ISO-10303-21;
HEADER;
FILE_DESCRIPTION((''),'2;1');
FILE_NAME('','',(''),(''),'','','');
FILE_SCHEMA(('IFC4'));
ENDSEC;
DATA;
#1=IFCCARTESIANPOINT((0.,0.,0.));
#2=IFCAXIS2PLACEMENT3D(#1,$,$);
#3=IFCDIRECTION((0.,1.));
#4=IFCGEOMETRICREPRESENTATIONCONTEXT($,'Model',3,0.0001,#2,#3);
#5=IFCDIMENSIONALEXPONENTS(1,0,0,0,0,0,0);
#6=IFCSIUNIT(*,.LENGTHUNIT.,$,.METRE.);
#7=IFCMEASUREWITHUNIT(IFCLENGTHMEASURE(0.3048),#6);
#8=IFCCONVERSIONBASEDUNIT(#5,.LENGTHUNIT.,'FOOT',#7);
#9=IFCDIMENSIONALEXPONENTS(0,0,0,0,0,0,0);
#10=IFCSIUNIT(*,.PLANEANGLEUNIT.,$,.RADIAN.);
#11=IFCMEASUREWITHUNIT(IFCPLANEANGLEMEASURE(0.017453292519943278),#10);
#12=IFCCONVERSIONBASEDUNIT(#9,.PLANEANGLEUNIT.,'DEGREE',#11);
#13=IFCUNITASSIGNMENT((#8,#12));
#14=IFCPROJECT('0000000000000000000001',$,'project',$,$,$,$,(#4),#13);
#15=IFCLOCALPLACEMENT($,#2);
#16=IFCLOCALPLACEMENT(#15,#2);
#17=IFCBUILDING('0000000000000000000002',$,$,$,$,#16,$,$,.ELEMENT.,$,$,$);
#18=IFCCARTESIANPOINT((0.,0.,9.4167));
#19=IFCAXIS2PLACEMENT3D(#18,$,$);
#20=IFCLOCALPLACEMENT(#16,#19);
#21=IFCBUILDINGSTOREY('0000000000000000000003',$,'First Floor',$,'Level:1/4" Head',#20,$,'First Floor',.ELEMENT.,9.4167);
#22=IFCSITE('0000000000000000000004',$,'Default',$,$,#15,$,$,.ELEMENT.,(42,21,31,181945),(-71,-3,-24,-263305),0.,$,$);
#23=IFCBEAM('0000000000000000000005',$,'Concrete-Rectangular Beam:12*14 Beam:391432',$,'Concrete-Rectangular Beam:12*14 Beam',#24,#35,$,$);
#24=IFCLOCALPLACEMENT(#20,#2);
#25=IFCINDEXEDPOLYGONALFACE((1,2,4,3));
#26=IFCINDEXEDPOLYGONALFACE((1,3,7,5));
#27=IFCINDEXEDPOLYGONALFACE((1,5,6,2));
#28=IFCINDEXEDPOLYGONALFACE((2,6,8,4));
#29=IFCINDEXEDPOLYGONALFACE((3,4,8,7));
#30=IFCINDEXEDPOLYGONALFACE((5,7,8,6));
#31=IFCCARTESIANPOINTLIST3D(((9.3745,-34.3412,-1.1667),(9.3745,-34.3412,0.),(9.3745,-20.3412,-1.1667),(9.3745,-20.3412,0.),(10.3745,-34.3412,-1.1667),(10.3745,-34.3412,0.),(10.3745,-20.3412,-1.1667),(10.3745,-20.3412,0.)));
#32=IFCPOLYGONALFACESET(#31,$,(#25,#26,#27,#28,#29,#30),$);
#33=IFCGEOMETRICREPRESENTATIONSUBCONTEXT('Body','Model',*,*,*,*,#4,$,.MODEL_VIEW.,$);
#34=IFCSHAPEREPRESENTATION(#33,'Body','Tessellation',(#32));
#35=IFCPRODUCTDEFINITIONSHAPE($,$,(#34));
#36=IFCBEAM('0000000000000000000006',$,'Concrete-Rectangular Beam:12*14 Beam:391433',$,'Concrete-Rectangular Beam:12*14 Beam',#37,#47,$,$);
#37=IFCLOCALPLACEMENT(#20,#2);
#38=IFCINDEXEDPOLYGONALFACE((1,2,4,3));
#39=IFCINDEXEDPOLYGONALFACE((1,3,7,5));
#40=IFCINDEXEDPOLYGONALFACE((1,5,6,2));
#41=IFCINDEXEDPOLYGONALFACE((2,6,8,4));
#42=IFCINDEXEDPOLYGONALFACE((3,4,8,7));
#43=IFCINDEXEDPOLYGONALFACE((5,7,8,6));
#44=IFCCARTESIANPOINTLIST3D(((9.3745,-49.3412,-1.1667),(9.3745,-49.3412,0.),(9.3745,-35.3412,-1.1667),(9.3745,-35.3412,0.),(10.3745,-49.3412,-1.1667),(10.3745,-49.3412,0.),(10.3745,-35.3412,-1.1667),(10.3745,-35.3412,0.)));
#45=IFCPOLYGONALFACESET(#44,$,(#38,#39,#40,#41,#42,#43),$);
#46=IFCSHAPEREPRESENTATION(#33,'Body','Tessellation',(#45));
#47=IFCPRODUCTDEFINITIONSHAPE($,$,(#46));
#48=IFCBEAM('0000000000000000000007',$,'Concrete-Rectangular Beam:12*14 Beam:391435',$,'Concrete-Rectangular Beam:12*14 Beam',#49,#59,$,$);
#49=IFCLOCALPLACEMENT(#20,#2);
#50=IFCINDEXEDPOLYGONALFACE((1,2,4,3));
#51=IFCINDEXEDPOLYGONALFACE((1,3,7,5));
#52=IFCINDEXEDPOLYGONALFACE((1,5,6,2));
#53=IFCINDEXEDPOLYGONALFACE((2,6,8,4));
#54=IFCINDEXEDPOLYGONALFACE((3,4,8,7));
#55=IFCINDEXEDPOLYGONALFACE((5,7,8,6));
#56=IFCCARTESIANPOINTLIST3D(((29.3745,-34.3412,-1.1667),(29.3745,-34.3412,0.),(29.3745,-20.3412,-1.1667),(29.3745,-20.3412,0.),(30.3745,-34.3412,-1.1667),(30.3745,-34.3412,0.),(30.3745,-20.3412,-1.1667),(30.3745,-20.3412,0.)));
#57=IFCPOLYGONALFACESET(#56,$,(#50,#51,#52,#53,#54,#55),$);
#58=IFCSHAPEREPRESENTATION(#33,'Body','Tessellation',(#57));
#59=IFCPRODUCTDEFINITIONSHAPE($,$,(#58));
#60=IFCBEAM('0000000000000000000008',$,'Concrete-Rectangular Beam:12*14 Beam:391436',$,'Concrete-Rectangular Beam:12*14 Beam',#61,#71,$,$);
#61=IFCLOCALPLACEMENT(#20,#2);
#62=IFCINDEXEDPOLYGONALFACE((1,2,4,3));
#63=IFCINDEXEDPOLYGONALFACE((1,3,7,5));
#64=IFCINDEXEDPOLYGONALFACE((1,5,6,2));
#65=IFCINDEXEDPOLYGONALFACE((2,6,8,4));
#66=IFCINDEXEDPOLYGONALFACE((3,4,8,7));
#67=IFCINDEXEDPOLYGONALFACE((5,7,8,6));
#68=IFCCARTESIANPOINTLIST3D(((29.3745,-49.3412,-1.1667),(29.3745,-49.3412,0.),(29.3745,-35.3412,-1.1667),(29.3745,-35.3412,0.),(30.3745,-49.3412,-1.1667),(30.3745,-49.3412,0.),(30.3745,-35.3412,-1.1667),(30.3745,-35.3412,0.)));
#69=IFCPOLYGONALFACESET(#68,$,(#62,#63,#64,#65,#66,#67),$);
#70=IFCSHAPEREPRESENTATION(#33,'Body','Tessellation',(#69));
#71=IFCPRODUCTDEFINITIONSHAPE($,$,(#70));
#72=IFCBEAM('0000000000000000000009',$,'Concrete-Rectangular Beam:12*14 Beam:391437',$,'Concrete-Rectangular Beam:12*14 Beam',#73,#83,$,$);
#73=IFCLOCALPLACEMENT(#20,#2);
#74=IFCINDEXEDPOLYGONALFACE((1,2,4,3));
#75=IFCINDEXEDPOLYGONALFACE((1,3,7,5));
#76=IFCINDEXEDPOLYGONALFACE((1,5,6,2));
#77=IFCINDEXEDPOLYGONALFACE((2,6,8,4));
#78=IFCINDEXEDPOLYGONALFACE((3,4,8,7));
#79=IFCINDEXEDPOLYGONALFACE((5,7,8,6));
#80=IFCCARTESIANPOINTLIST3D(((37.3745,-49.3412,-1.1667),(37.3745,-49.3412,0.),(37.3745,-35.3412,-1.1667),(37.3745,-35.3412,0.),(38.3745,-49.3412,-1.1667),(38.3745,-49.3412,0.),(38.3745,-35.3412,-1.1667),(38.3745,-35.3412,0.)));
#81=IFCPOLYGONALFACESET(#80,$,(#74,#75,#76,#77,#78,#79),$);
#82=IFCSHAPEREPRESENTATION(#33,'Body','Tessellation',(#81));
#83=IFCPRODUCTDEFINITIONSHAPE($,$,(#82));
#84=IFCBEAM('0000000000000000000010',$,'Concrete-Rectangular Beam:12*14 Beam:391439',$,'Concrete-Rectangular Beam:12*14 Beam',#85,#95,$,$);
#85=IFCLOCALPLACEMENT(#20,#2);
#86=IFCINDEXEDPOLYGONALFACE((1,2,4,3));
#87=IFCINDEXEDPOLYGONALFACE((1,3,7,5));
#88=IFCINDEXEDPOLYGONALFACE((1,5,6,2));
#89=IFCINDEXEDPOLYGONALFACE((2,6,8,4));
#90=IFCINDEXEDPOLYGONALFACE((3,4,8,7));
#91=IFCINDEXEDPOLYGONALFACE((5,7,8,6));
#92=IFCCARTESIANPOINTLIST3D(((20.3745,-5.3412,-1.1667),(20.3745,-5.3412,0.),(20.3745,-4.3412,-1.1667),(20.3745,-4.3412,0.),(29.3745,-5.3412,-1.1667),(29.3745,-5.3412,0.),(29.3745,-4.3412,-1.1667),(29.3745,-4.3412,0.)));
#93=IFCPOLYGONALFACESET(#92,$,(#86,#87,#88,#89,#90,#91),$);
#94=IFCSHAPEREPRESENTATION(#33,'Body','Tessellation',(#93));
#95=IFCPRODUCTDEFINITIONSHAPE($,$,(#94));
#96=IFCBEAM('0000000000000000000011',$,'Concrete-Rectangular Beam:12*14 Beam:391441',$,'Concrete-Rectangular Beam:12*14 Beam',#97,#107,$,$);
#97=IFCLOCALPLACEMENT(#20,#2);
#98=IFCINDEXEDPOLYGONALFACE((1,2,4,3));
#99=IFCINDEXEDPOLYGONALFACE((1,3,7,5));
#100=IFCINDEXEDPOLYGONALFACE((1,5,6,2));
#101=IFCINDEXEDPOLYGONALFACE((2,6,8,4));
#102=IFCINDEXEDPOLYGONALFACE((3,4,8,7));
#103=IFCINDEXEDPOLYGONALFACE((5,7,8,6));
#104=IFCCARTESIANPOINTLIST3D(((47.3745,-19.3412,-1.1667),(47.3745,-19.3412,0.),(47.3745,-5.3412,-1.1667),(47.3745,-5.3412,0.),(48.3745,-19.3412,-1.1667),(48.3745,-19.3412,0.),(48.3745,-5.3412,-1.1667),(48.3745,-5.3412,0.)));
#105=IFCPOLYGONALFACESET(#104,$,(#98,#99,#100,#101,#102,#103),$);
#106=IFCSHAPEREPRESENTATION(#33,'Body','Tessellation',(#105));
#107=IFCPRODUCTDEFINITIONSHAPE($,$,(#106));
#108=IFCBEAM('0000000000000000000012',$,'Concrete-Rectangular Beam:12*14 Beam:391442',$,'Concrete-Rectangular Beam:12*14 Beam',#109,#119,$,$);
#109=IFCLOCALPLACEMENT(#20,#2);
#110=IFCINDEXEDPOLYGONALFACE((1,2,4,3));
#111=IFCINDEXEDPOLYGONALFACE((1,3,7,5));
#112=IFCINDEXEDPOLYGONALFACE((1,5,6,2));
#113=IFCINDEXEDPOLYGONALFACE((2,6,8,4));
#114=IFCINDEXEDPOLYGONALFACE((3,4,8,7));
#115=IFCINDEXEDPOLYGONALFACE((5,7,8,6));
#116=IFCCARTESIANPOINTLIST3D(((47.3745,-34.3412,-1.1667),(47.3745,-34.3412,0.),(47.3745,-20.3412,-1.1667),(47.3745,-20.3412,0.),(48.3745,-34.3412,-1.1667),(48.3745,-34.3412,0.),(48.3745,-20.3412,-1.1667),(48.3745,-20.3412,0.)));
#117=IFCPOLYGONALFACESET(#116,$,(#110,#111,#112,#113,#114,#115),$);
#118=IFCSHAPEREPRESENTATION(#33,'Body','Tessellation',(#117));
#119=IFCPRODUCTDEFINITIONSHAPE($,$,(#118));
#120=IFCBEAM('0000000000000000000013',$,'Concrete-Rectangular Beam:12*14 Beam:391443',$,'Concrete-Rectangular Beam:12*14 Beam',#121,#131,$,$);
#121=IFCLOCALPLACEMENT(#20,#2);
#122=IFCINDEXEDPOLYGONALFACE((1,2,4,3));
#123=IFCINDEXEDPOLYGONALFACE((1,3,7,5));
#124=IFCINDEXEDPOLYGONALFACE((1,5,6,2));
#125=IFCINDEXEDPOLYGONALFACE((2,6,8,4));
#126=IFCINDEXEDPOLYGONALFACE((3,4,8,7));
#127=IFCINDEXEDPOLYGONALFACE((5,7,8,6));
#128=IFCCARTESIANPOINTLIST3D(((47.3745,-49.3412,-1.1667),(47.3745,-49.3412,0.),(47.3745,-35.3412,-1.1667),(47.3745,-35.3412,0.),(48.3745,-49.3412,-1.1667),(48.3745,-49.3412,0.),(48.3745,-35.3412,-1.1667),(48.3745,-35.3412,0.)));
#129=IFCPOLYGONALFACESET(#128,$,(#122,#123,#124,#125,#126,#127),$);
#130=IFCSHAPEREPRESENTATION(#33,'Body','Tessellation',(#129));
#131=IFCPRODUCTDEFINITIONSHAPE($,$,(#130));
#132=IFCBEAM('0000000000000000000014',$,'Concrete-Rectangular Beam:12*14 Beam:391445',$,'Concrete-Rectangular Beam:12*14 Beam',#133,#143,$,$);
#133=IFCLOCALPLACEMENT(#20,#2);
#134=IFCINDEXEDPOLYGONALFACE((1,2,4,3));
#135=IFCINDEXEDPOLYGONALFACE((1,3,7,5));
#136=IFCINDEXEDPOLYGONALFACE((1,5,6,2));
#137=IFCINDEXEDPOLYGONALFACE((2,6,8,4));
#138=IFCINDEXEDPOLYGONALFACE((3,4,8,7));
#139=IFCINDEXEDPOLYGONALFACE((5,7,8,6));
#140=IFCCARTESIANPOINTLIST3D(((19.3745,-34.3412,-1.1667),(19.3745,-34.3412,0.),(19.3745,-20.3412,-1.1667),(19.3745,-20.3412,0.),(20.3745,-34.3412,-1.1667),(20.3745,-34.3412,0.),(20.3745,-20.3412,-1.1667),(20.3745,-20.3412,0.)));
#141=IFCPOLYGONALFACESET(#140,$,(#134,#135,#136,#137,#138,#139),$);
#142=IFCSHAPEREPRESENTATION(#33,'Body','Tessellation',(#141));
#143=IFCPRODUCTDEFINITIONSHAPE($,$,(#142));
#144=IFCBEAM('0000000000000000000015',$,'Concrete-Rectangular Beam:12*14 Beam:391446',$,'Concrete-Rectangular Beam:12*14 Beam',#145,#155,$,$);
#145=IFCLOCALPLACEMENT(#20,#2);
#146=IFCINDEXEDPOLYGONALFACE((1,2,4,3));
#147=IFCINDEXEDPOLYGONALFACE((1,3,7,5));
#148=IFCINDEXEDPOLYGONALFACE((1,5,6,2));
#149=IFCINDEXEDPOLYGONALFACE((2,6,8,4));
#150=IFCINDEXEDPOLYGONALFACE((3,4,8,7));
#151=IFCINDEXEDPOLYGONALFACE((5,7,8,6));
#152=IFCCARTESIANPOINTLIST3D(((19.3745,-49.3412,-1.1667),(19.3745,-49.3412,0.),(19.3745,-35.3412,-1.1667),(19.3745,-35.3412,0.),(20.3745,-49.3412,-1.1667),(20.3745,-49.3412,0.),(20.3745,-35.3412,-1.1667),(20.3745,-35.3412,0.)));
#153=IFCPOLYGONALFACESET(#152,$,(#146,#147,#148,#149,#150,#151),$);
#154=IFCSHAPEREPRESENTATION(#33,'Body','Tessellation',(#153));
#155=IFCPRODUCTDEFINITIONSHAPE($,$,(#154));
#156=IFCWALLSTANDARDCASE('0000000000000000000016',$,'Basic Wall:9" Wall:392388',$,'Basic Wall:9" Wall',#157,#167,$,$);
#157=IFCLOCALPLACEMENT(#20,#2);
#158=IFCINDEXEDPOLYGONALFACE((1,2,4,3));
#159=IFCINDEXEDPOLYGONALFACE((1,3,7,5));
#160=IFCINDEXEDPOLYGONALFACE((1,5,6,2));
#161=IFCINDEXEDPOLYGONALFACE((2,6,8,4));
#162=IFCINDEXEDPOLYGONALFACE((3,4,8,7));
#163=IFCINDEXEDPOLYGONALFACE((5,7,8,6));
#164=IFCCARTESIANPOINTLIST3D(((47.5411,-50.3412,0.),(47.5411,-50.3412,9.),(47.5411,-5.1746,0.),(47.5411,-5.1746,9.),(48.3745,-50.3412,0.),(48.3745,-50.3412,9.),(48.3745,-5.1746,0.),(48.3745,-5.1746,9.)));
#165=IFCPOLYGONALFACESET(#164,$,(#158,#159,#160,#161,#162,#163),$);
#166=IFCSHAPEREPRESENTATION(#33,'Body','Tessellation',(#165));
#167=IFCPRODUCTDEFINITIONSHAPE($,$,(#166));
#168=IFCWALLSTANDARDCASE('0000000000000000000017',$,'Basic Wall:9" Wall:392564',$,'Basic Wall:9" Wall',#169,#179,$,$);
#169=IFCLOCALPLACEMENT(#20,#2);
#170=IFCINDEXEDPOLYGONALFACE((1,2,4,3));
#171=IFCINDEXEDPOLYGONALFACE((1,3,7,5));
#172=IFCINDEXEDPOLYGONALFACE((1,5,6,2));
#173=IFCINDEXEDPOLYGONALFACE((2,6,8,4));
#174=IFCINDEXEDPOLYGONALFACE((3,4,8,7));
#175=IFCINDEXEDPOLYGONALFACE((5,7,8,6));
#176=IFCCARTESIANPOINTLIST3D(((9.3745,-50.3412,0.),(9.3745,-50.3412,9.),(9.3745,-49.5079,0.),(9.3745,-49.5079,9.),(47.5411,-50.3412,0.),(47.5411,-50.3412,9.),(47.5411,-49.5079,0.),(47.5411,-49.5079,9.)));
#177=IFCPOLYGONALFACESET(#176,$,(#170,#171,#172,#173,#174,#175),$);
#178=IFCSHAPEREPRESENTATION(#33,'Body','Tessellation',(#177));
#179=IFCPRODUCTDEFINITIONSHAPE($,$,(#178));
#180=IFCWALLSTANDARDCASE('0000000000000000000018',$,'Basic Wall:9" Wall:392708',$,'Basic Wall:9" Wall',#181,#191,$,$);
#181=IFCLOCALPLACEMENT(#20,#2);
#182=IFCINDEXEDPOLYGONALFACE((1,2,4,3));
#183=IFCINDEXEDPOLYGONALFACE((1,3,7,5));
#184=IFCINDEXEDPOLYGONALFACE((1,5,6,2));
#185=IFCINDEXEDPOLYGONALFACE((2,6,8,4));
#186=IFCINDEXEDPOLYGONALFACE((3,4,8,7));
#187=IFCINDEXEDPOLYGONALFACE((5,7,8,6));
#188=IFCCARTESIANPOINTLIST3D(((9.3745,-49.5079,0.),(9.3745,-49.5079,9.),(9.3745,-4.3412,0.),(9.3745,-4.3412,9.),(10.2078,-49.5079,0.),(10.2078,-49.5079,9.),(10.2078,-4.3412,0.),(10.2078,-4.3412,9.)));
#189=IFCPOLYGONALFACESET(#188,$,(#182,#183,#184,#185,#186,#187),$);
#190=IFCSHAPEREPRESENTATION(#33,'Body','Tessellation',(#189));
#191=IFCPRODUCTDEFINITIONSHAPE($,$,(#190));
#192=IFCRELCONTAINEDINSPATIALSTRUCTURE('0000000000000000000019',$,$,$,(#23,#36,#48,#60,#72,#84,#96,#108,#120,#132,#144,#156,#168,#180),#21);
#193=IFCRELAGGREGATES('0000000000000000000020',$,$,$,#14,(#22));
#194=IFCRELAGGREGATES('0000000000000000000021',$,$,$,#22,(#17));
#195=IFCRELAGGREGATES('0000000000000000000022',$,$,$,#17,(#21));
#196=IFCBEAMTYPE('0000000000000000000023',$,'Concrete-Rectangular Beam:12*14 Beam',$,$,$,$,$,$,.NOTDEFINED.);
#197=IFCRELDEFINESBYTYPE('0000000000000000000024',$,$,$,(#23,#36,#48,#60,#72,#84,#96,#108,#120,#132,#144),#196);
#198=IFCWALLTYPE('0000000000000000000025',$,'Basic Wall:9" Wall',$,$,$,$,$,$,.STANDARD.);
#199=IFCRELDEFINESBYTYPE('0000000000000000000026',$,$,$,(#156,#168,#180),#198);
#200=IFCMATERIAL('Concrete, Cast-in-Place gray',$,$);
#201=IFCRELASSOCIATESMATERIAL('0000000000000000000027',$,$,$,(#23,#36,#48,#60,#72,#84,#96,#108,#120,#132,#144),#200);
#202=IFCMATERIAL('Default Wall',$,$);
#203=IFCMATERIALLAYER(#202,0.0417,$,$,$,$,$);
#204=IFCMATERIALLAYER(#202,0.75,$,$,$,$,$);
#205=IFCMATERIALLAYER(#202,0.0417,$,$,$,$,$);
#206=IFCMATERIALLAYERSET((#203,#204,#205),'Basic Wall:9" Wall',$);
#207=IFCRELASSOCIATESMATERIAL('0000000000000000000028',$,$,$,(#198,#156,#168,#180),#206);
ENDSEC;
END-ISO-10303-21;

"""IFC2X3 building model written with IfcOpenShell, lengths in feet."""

from ifc_helpers import new_model, entity, si_unit, converted_unit, direction, frame, frame_2d, origin, place, context, subcontext, project, spatial, rectangle, extrude, material, layer, layer_set, layer_usage, type_object, element, save


model = new_model("IFC2X3")

# Units and contexts
model_context = context("Model", 3, precision=0.0001, world=origin(), true_north=direction((0.0, 1.0)))
body_context = subcontext(model_context, "Body", "Model", "MODEL_VIEW")
ifc_project = project(units=[converted_unit("LENGTHUNIT", "FOOT", entity("IfcLengthMeasure", 0.3048), si_unit("LENGTHUNIT", "METRE"), dimensions=[1, 0, 0, 0, 0, 0, 0]), converted_unit("PLANEANGLEUNIT", "DEGREE", entity("IfcPlaneAngleMeasure", 0.017453292519943278), si_unit("PLANEANGLEUNIT", "RADIAN"), dimensions=[0, 0, 0, 0, 0, 0, 0])], contexts=[model_context])

# Site, building, storey
site_placement = place(None, origin())
site = spatial("IfcSite", under=ifc_project, at=site_placement, Name="Default", CompositionType="ELEMENT", RefLatitude=(42, 21, 31, 181945), RefLongitude=(-71, -3, -24, -263305), RefElevation=0.0)
building_placement = place(site_placement, origin())
building = spatial("IfcBuilding", under=site, at=building_placement, CompositionType="ELEMENT")
storey_placement = place(building_placement, frame((0.0, 0.0, 9.4167)))
storey = spatial("IfcBuildingStorey", under=building, at=storey_placement, Name="First Floor", ObjectType="Level:1/4\" Head", LongName="First Floor", CompositionType="ELEMENT", Elevation=9.4167)

# Beams
ifc_material_1 = material(Name="Concrete, Cast-in-Place gray")
beam_type = type_object("IfcBeamType", Name="Concrete-Rectangular Beam:12*14 Beam", PredefinedType="NOTDEFINED")
beam_1_placement = place(storey_placement, frame((9.8745, -19.8412, 0.0), z_axis=(0.0, 0.0, 1.0), x_axis=(0.0, -1.0, 0.0)))
element("IfcBeam", 1, at=beam_1_placement, inside=storey, type_object=beam_type, material=ifc_material_1, Name="Concrete-Rectangular Beam:12*14 Beam:391432", ObjectType="Concrete-Rectangular Beam:12*14 Beam", context=body_context, shape_type="SweptSolid", body=[
    extrude(rectangle(XDim=1.1667, YDim=1.0, at=frame_2d((0.0, 0.0), x_axis=(1.0, 0.0))), frame((0.5, 0.0, -0.5833), z_axis=(1.0, 0.0, 0.0), x_axis=(0.0, 0.0, -1.0)), (0.0, 0.0, 1.0), 14.0),
])
beam_2_placement = place(storey_placement, frame((9.8745, -34.8412, 0.0), z_axis=(0.0, 0.0, 1.0), x_axis=(0.0, -1.0, 0.0)))
element("IfcBeam", 2, at=beam_2_placement, inside=storey, type_object=beam_type, material=ifc_material_1, Name="Concrete-Rectangular Beam:12*14 Beam:391433", ObjectType="Concrete-Rectangular Beam:12*14 Beam", context=body_context, shape_type="SweptSolid", body=[
    extrude(rectangle(XDim=1.1667, YDim=1.0, at=frame_2d((0.0, 0.0), x_axis=(1.0, 0.0))), frame((0.5, 0.0, -0.5833), z_axis=(1.0, 0.0, 0.0), x_axis=(0.0, 0.0, -1.0)), (0.0, 0.0, 1.0), 14.0),
])
beam_3_placement = place(storey_placement, frame((29.8745, -19.8412, 0.0), z_axis=(0.0, 0.0, 1.0), x_axis=(0.0, -1.0, 0.0)))
element("IfcBeam", 3, at=beam_3_placement, inside=storey, type_object=beam_type, material=ifc_material_1, Name="Concrete-Rectangular Beam:12*14 Beam:391435", ObjectType="Concrete-Rectangular Beam:12*14 Beam", context=body_context, shape_type="SweptSolid", body=[
    extrude(rectangle(XDim=1.1667, YDim=1.0, at=frame_2d((0.0, 0.0), x_axis=(1.0, 0.0))), frame((0.5, 0.0, -0.5833), z_axis=(1.0, 0.0, 0.0), x_axis=(0.0, 0.0, -1.0)), (0.0, 0.0, 1.0), 14.0),
])
beam_4_placement = place(storey_placement, frame((29.8745, -34.8412, 0.0), z_axis=(0.0, 0.0, 1.0), x_axis=(0.0, -1.0, 0.0)))
element("IfcBeam", 4, at=beam_4_placement, inside=storey, type_object=beam_type, material=ifc_material_1, Name="Concrete-Rectangular Beam:12*14 Beam:391436", ObjectType="Concrete-Rectangular Beam:12*14 Beam", context=body_context, shape_type="SweptSolid", body=[
    extrude(rectangle(XDim=1.1667, YDim=1.0, at=frame_2d((0.0, 0.0), x_axis=(1.0, 0.0))), frame((0.5, 0.0, -0.5833), z_axis=(1.0, 0.0, 0.0), x_axis=(0.0, 0.0, -1.0)), (0.0, 0.0, 1.0), 14.0),
])
beam_5_placement = place(storey_placement, frame((37.8745, -34.8412, 0.0), z_axis=(0.0, 0.0, 1.0), x_axis=(0.0, -1.0, 0.0)))
element("IfcBeam", 5, at=beam_5_placement, inside=storey, type_object=beam_type, material=ifc_material_1, Name="Concrete-Rectangular Beam:12*14 Beam:391437", ObjectType="Concrete-Rectangular Beam:12*14 Beam", context=body_context, shape_type="SweptSolid", body=[
    extrude(rectangle(XDim=1.1667, YDim=1.0, at=frame_2d((0.0, 0.0), x_axis=(1.0, 0.0))), frame((0.5, 0.0, -0.5833), z_axis=(1.0, 0.0, 0.0), x_axis=(0.0, 0.0, -1.0)), (0.0, 0.0, 1.0), 14.0),
])
beam_6_placement = place(storey_placement, frame((19.8745, -4.8412, 0.0)))
element("IfcBeam", 6, at=beam_6_placement, inside=storey, type_object=beam_type, material=ifc_material_1, Name="Concrete-Rectangular Beam:12*14 Beam:391439", ObjectType="Concrete-Rectangular Beam:12*14 Beam", context=body_context, shape_type="SweptSolid", body=[
    extrude(rectangle(XDim=1.1667, YDim=1.0, at=frame_2d((0.0, 0.0), x_axis=(1.0, 0.0))), frame((0.5, 0.0, -0.5833), z_axis=(1.0, 0.0, 0.0), x_axis=(0.0, 0.0, -1.0)), (0.0, 0.0, 1.0), 9.0),
])
beam_7_placement = place(storey_placement, frame((47.8745, -4.8412, 0.0), z_axis=(0.0, 0.0, 1.0), x_axis=(0.0, -1.0, 0.0)))
element("IfcBeam", 7, at=beam_7_placement, inside=storey, type_object=beam_type, material=ifc_material_1, Name="Concrete-Rectangular Beam:12*14 Beam:391441", ObjectType="Concrete-Rectangular Beam:12*14 Beam", context=body_context, shape_type="SweptSolid", body=[
    extrude(rectangle(XDim=1.1667, YDim=1.0, at=frame_2d((0.0, 0.0), x_axis=(1.0, 0.0))), frame((0.5, 0.0, -0.5833), z_axis=(1.0, 0.0, 0.0), x_axis=(0.0, 0.0, -1.0)), (0.0, 0.0, 1.0), 14.0),
])
beam_8_placement = place(storey_placement, frame((47.8745, -19.8412, 0.0), z_axis=(0.0, 0.0, 1.0), x_axis=(0.0, -1.0, 0.0)))
element("IfcBeam", 8, at=beam_8_placement, inside=storey, type_object=beam_type, material=ifc_material_1, Name="Concrete-Rectangular Beam:12*14 Beam:391442", ObjectType="Concrete-Rectangular Beam:12*14 Beam", context=body_context, shape_type="SweptSolid", body=[
    extrude(rectangle(XDim=1.1667, YDim=1.0, at=frame_2d((0.0, 0.0), x_axis=(1.0, 0.0))), frame((0.5, 0.0, -0.5833), z_axis=(1.0, 0.0, 0.0), x_axis=(0.0, 0.0, -1.0)), (0.0, 0.0, 1.0), 14.0),
])
beam_9_placement = place(storey_placement, frame((47.8745, -34.8412, 0.0), z_axis=(0.0, 0.0, 1.0), x_axis=(0.0, -1.0, 0.0)))
element("IfcBeam", 9, at=beam_9_placement, inside=storey, type_object=beam_type, material=ifc_material_1, Name="Concrete-Rectangular Beam:12*14 Beam:391443", ObjectType="Concrete-Rectangular Beam:12*14 Beam", context=body_context, shape_type="SweptSolid", body=[
    extrude(rectangle(XDim=1.1667, YDim=1.0, at=frame_2d((0.0, 0.0), x_axis=(1.0, 0.0))), frame((0.5, 0.0, -0.5833), z_axis=(1.0, 0.0, 0.0), x_axis=(0.0, 0.0, -1.0)), (0.0, 0.0, 1.0), 14.0),
])
beam_10_placement = place(storey_placement, frame((19.8745, -19.8412, 0.0), z_axis=(0.0, 0.0, 1.0), x_axis=(0.0, -1.0, 0.0)))
element("IfcBeam", 10, at=beam_10_placement, inside=storey, type_object=beam_type, material=ifc_material_1, Name="Concrete-Rectangular Beam:12*14 Beam:391445", ObjectType="Concrete-Rectangular Beam:12*14 Beam", context=body_context, shape_type="SweptSolid", body=[
    extrude(rectangle(XDim=1.1667, YDim=1.0, at=frame_2d((0.0, 0.0), x_axis=(1.0, 0.0))), frame((0.5, 0.0, -0.5833), z_axis=(1.0, 0.0, 0.0), x_axis=(0.0, 0.0, -1.0)), (0.0, 0.0, 1.0), 14.0),
])
beam_11_placement = place(storey_placement, frame((19.8745, -34.8412, 0.0), z_axis=(0.0, 0.0, 1.0), x_axis=(0.0, -1.0, 0.0)))
element("IfcBeam", 11, at=beam_11_placement, inside=storey, type_object=beam_type, material=ifc_material_1, Name="Concrete-Rectangular Beam:12*14 Beam:391446", ObjectType="Concrete-Rectangular Beam:12*14 Beam", context=body_context, shape_type="SweptSolid", body=[
    extrude(rectangle(XDim=1.1667, YDim=1.0, at=frame_2d((0.0, 0.0), x_axis=(1.0, 0.0))), frame((0.5, 0.0, -0.5833), z_axis=(1.0, 0.0, 0.0), x_axis=(0.0, 0.0, -1.0)), (0.0, 0.0, 1.0), 14.0),
])

# Walls
ifc_material_2 = material(Name="Default Wall")
ifc_layer_1 = layer(ifc_material_2, 0.0417)
ifc_layer_2 = layer(ifc_material_2, 0.75)
ifc_layer_3 = layer(ifc_material_2, 0.0417)
ifc_layer_set_1 = layer_set([ifc_layer_1, ifc_layer_2, ifc_layer_3], Name="Basic Wall:9\" Wall")
ifc_layer_usage_1 = layer_usage(ifc_layer_set_1, "AXIS2", "NEGATIVE", 0.4167)
wall_type_1 = type_object("IfcWallType", Name="Basic Wall:9\" Wall", PredefinedType="STANDARD", material=ifc_layer_set_1)
wall_1_placement = place(storey_placement, frame((47.9578, -5.1746, 0.0), z_axis=(0.0, 0.0, 1.0), x_axis=(0.0, -1.0, 0.0)))
element("IfcWallStandardCase", 12, at=wall_1_placement, inside=storey, type_object=wall_type_1, material=ifc_layer_usage_1, Name="Basic Wall:9\" Wall:392388", ObjectType="Basic Wall:9\" Wall", context=body_context, shape_type="SweptSolid", body=[
    extrude(rectangle(XDim=45.1667, YDim=0.8333, at=frame_2d((22.5833, 0.0), x_axis=(-1.0, 0.0))), origin(), (0.0, 0.0, 1.0), 9.0),
])
wall_2_placement = place(storey_placement, frame((47.5411, -49.9246, 0.0), z_axis=(0.0, 0.0, 1.0), x_axis=(-1.0, 0.0, 0.0)))
element("IfcWallStandardCase", 13, at=wall_2_placement, inside=storey, type_object=wall_type_1, material=ifc_layer_usage_1, Name="Basic Wall:9\" Wall:392564", ObjectType="Basic Wall:9\" Wall", context=body_context, shape_type="SweptSolid", body=[
    extrude(rectangle(XDim=38.1667, YDim=0.8333, at=frame_2d((19.0833, 0.0), x_axis=(-1.0, 0.0))), origin(), (0.0, 0.0, 1.0), 9.0),
])
wall_3_placement = place(storey_placement, frame((9.7911, -49.5079, 0.0), z_axis=(0.0, 0.0, 1.0), x_axis=(0.0, 1.0, 0.0)))
element("IfcWallStandardCase", 14, at=wall_3_placement, inside=storey, type_object=wall_type_1, material=ifc_layer_usage_1, Name="Basic Wall:9\" Wall:392708", ObjectType="Basic Wall:9\" Wall", context=body_context, shape_type="SweptSolid", body=[
    extrude(rectangle(XDim=45.1667, YDim=0.8333, at=frame_2d((22.5833, 0.0), x_axis=(-1.0, 0.0))), origin(), (0.0, 0.0, 1.0), 9.0),
])

save(model, "model.ifc")
